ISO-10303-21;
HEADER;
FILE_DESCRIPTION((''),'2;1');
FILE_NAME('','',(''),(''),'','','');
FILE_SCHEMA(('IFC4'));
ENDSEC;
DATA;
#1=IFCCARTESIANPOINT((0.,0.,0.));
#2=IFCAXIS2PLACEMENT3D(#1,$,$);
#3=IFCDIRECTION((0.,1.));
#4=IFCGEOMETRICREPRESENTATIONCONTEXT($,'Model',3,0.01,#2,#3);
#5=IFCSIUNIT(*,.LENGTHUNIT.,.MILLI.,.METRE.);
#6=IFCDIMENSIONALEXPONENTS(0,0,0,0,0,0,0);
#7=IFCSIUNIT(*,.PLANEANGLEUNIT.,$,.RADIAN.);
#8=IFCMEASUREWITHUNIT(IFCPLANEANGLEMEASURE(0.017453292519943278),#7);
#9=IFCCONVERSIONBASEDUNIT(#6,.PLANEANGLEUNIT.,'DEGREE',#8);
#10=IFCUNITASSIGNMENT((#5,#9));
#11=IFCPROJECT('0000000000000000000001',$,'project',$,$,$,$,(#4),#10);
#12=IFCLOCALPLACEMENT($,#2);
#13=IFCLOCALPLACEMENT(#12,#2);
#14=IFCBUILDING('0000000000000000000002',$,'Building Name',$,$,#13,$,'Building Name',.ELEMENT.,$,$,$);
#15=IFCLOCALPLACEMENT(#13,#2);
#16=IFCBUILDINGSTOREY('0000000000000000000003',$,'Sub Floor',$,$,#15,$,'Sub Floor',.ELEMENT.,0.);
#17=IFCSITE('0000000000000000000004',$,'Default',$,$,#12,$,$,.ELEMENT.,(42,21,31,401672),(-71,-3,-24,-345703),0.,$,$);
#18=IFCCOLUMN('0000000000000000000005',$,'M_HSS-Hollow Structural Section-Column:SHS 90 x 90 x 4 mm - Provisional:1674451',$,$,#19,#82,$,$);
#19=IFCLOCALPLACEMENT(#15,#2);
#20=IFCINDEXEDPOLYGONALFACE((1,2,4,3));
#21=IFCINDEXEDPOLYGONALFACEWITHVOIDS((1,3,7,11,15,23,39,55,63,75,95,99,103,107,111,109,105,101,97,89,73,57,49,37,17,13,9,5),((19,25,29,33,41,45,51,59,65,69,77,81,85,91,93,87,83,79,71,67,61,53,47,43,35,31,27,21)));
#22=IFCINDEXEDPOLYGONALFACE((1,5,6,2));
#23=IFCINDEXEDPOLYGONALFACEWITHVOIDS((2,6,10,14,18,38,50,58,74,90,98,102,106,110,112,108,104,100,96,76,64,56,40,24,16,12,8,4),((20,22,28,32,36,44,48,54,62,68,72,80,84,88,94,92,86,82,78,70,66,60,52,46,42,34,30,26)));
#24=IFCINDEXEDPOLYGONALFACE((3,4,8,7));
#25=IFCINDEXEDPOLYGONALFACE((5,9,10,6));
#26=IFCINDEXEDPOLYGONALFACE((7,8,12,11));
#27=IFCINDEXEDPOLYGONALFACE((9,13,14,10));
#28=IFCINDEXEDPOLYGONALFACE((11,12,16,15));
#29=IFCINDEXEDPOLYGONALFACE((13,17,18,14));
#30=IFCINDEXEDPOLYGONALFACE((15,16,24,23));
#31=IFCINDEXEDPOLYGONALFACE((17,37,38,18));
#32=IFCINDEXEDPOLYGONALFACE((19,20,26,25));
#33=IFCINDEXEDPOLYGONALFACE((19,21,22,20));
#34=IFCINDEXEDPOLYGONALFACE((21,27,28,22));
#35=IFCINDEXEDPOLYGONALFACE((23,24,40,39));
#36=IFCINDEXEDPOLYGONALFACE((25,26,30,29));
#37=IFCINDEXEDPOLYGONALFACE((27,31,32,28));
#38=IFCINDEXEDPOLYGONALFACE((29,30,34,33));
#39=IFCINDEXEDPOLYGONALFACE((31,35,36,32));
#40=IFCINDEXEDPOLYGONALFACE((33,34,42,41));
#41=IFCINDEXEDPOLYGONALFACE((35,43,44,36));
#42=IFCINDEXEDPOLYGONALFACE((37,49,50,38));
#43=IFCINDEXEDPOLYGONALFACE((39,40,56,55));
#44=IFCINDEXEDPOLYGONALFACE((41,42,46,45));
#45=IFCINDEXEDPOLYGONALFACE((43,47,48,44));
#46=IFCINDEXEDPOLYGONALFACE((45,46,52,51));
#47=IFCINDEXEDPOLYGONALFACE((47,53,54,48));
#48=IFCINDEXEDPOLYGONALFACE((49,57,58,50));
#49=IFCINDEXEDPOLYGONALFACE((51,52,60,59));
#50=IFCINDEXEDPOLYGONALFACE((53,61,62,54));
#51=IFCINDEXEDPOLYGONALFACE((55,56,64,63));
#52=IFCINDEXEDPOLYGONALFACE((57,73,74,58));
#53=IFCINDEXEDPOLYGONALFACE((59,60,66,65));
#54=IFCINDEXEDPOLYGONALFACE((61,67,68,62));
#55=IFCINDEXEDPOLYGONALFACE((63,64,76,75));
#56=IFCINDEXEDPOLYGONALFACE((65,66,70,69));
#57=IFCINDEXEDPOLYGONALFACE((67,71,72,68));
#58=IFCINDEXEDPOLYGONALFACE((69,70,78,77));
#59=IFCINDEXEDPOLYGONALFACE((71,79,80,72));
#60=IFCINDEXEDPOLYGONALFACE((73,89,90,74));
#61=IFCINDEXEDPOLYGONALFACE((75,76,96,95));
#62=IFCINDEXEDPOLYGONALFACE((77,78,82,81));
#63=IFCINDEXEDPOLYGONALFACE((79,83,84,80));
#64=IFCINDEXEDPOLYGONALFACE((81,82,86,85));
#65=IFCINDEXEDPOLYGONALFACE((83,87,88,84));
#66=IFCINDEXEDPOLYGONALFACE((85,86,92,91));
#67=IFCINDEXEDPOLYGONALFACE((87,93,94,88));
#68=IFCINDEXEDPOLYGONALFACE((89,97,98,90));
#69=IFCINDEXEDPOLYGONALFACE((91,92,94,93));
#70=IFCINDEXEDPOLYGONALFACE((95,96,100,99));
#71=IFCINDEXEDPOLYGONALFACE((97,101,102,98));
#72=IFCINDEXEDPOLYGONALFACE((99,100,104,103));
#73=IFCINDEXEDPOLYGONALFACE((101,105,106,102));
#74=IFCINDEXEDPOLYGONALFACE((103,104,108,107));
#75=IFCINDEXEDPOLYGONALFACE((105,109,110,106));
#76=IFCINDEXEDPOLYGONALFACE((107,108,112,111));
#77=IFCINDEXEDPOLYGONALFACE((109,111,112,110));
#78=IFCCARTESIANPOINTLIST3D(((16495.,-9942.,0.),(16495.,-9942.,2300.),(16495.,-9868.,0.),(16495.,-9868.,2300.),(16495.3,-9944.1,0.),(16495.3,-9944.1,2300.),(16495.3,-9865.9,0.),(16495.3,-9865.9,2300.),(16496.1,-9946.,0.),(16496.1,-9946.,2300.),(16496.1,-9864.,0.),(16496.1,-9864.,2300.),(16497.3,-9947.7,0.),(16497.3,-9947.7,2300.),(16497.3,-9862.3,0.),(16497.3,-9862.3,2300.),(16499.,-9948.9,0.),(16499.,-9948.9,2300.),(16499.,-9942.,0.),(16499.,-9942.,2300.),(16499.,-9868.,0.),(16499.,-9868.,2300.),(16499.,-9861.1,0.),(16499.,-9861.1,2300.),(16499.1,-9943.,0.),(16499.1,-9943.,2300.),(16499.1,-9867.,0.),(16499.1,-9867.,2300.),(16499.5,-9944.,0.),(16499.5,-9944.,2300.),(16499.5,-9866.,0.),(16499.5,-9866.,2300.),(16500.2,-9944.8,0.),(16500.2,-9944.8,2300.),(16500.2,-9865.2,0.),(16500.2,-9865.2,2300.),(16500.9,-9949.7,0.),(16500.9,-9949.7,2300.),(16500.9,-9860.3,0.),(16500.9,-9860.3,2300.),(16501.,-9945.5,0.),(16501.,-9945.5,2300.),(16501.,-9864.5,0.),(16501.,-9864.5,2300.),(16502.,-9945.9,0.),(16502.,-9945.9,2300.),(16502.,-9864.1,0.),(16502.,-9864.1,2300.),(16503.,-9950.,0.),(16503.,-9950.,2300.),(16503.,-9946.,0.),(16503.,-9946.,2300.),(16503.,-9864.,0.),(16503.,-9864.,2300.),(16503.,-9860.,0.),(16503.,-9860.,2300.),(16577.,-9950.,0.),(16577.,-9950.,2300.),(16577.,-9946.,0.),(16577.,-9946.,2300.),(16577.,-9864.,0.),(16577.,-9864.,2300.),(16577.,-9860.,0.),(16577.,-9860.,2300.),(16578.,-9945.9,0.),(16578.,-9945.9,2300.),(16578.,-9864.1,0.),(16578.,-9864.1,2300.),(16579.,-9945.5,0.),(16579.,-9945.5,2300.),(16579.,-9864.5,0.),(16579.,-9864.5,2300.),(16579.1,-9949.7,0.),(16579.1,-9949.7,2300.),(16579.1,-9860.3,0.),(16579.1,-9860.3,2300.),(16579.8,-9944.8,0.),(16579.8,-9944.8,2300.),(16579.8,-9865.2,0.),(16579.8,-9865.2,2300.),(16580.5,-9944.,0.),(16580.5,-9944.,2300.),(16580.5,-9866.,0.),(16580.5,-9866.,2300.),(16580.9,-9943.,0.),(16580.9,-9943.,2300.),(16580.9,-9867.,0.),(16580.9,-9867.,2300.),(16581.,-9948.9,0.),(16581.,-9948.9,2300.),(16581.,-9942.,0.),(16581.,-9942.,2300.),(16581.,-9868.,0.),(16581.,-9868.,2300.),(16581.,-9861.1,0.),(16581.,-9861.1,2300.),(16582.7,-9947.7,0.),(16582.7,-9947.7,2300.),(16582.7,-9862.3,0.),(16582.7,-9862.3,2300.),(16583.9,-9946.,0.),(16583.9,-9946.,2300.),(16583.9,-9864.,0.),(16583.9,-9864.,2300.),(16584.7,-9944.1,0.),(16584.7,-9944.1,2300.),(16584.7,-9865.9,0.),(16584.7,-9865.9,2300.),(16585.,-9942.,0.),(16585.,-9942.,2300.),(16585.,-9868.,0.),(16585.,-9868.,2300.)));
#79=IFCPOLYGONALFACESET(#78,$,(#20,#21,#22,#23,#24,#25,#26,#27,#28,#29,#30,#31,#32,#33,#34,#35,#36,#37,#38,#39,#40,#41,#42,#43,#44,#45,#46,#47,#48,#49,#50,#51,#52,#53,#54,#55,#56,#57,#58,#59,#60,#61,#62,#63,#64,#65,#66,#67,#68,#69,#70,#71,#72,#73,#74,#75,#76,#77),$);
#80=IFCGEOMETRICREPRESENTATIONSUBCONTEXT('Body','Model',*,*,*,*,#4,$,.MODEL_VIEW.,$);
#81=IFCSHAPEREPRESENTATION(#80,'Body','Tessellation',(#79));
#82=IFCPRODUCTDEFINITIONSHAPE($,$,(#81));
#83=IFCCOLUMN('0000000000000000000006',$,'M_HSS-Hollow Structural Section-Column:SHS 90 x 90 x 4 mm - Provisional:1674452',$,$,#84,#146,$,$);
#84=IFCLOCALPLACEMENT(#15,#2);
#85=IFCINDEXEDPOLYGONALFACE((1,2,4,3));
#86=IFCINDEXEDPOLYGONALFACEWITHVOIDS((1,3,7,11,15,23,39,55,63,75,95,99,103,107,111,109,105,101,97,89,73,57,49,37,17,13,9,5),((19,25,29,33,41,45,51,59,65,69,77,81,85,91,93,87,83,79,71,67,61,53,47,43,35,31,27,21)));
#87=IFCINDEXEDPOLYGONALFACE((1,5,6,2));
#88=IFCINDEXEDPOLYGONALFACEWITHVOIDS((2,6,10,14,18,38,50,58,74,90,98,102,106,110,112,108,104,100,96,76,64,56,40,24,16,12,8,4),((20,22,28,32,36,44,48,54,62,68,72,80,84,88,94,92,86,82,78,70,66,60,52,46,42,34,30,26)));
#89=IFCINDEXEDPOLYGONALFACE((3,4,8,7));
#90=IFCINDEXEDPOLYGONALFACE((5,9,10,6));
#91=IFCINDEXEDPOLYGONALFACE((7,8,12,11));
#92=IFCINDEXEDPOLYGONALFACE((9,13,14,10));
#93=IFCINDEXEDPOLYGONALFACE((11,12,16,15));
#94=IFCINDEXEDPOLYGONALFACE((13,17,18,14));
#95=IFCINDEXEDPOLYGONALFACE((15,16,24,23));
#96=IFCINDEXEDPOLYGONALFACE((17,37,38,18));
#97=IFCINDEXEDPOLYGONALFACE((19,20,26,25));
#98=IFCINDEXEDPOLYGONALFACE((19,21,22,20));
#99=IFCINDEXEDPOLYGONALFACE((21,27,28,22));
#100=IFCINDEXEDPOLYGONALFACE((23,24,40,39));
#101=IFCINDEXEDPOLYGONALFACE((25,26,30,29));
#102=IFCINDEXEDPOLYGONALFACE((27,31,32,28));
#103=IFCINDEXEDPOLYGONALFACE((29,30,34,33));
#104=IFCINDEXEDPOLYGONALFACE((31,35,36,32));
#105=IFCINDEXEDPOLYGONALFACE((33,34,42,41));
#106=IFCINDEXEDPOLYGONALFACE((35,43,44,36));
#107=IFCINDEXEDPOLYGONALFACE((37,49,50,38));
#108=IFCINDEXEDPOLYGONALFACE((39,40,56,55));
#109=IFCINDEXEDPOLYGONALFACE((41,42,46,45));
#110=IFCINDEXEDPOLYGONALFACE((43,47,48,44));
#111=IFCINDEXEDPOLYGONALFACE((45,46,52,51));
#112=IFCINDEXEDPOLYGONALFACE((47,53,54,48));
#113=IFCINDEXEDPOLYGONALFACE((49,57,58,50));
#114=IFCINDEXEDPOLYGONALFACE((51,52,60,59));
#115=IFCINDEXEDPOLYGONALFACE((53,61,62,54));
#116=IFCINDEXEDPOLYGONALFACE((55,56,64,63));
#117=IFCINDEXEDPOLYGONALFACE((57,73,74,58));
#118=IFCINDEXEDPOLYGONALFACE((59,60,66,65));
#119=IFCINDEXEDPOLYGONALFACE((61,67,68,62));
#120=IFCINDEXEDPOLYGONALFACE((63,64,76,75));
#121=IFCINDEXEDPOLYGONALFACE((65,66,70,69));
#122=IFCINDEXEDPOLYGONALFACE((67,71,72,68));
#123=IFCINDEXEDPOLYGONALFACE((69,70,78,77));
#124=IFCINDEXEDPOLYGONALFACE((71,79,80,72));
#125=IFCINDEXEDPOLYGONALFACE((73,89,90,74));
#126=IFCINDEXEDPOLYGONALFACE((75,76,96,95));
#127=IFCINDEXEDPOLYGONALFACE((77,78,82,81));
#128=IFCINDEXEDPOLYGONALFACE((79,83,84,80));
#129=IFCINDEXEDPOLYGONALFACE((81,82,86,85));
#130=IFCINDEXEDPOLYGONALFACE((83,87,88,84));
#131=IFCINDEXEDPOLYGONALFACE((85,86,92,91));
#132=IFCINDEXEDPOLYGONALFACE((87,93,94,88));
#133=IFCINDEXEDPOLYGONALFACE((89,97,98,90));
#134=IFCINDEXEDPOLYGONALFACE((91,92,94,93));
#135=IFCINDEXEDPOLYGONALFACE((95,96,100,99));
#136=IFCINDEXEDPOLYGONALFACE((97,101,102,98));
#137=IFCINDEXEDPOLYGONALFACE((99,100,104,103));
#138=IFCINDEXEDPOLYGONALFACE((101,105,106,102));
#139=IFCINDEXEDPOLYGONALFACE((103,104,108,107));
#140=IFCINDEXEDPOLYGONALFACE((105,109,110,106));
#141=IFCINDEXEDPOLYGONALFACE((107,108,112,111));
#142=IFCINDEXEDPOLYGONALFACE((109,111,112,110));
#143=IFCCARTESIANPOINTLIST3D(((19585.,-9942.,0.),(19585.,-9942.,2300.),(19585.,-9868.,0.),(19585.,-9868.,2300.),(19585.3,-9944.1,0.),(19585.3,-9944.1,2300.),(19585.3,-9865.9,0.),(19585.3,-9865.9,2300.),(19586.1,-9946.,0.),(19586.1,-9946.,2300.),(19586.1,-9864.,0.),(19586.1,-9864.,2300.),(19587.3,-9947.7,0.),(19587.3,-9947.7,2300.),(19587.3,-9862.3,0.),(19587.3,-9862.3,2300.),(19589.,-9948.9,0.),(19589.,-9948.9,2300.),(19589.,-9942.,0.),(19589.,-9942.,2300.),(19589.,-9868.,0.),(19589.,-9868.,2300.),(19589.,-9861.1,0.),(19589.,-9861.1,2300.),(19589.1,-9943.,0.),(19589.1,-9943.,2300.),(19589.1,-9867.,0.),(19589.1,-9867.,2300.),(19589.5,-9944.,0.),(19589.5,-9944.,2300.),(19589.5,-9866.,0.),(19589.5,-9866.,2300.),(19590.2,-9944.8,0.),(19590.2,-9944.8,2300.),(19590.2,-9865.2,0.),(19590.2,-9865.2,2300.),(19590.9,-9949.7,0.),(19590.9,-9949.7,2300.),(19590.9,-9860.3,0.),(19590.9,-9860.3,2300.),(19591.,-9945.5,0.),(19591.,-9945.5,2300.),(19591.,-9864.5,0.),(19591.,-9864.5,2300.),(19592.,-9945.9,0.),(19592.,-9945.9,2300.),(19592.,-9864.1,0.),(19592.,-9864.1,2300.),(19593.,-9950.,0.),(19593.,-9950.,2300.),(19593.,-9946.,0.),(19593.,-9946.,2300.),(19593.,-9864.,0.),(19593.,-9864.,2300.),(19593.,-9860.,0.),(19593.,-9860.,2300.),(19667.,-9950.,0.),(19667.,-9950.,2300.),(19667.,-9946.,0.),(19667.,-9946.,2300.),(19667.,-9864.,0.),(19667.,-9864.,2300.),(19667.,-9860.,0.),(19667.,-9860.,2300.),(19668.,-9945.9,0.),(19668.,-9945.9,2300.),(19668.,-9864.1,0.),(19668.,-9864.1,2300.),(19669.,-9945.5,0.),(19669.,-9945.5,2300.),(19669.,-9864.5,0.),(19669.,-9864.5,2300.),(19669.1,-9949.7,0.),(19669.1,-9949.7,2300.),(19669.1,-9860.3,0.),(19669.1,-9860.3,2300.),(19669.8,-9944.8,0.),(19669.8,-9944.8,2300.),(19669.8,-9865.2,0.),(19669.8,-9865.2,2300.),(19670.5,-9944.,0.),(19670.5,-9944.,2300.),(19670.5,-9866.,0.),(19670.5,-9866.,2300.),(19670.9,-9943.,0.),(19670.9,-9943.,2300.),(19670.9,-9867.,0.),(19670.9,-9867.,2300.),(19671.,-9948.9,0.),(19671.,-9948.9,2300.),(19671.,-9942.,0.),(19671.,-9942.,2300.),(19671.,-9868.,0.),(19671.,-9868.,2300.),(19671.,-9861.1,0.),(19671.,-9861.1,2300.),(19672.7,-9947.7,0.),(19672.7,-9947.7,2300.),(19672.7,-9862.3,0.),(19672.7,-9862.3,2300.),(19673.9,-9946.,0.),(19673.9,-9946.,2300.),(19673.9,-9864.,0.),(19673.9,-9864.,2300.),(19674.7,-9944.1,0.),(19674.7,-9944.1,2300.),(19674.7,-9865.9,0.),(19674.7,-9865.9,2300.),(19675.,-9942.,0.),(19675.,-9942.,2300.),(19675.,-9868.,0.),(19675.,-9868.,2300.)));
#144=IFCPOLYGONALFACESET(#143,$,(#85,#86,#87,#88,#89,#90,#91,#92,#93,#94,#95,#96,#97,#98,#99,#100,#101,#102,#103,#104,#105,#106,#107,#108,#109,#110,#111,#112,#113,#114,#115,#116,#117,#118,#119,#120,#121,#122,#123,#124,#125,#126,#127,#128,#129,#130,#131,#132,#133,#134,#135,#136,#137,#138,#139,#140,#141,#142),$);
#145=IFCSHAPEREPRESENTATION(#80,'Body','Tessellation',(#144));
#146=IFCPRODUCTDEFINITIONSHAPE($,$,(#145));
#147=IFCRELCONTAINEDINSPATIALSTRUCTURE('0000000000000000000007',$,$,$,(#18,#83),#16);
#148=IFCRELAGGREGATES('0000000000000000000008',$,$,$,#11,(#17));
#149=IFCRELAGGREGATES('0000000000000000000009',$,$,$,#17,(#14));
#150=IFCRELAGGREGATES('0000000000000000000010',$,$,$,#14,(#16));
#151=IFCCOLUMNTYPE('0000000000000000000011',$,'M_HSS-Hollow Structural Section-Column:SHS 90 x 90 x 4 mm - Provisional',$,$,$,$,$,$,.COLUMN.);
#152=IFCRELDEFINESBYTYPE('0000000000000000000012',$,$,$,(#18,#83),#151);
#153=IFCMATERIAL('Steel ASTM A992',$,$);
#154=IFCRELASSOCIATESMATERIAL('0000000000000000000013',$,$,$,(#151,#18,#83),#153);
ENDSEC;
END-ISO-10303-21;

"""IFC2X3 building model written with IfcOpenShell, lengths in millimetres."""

from ifc_helpers import new_model, entity, si_unit, converted_unit, direction, frame, frame_2d, origin, place, context, subcontext, project, spatial, polyline, circle_curve, parameter, trimmed, segment, composite_curve, outline, extrude, source, transform, mapped, material, type_object, type_shapes, element, save


model = new_model("IFC2X3")

# Units and contexts
model_context = context("Model", 3, precision=0.01, world=origin(), true_north=direction((0.0, 1.0)))
body_context = subcontext(model_context, "Body", "Model", "MODEL_VIEW")
ifc_project = project(units=[si_unit("LENGTHUNIT", "METRE", prefix="MILLI"), converted_unit("PLANEANGLEUNIT", "DEGREE", entity("IfcPlaneAngleMeasure", 0.017453292519943278), si_unit("PLANEANGLEUNIT", "RADIAN"), dimensions=[0, 0, 0, 0, 0, 0, 0])], contexts=[model_context])

# Site, building, storey
site_placement = place(None, origin())
site = spatial("IfcSite", under=ifc_project, at=site_placement, Name="Default", CompositionType="ELEMENT", RefLatitude=(42, 21, 31, 401672), RefLongitude=(-71, -3, -24, -345703), RefElevation=0.0)
building_placement = place(site_placement, origin())
building = spatial("IfcBuilding", under=site, at=building_placement, Name="Building Name", LongName="Building Name", CompositionType="ELEMENT")
storey_placement = place(building_placement, origin())
storey = spatial("IfcBuildingStorey", under=building, at=storey_placement, Name="Sub Floor", LongName="Sub Floor", CompositionType="ELEMENT", Elevation=0.0)

# Columns
ifc_material_1 = material(Name="Steel ASTM A992")
column_type = type_object("IfcColumnType", Name="M_HSS-Hollow Structural Section-Column:SHS 90 x 90 x 4 mm - Provisional", PredefinedType="COLUMN", material=ifc_material_1)
shared_shape_1 = source(origin(), body_context, "Body", "SweptSolid", [
    extrude(outline(composite_curve([segment(polyline([(-37.0, -45.0), (37.0, -45.0)]), True, "CONTINUOUS"), segment(trimmed(circle_curve(frame_2d((37.0, -37.0), x_axis=(-1.0, 0.0)), 8.0), [parameter(90.0)], [parameter(180.0)], True, "PARAMETER"), True, "CONTINUOUS"), segment(polyline([(45.0, -37.0), (45.0, 37.0)]), True, "CONTINUOUS"), segment(trimmed(circle_curve(frame_2d((37.0, 37.0), x_axis=(-1.0, 0.0)), 8.0), [parameter(180.0)], [parameter(270.0)], True, "PARAMETER"), True, "CONTINUOUS"), segment(polyline([(37.0, 45.0), (-37.0, 45.0)]), True, "CONTINUOUS"), segment(trimmed(circle_curve(frame_2d((-37.0, 37.0), x_axis=(-1.0, 0.0)), 8.0), [parameter(270.0)], [parameter(360.0)], True, "PARAMETER"), True, "CONTINUOUS"), segment(polyline([(-45.0, 37.0), (-45.0, -37.0)]), True, "CONTINUOUS"), segment(trimmed(circle_curve(frame_2d((-37.0, -37.0), x_axis=(-1.0, 0.0)), 8.0), [parameter(360.0)], [parameter(90.0)], True, "PARAMETER"), True, "CONTINUOUS")], self_intersect=False), holes=[composite_curve([segment(trimmed(circle_curve(frame_2d((-37.0, -37.0), x_axis=(-1.0, 0.0)), 4.0), [parameter(0.0)], [parameter(90.0)], True, "PARAMETER"), False, "CONTINUOUS"), segment(polyline([(-41.0, -37.0), (-41.0, 37.0)]), True, "CONTINUOUS"), segment(trimmed(circle_curve(frame_2d((-37.0, 37.0), x_axis=(-1.0, 0.0)), 4.0), [parameter(270.0)], [parameter(0.0)], True, "PARAMETER"), False, "CONTINUOUS"), segment(polyline([(-37.0, 41.0), (37.0, 41.0)]), True, "CONTINUOUS"), segment(trimmed(circle_curve(frame_2d((37.0, 37.0), x_axis=(-1.0, 0.0)), 4.0), [parameter(180.0)], [parameter(270.0)], True, "PARAMETER"), False, "CONTINUOUS"), segment(polyline([(41.0, 37.0), (41.0, -37.0)]), True, "CONTINUOUS"), segment(trimmed(circle_curve(frame_2d((37.0, -37.0), x_axis=(-1.0, 0.0)), 4.0), [parameter(90.0)], [parameter(180.0)], True, "PARAMETER"), False, "CONTINUOUS"), segment(polyline([(37.0, -41.0), (-37.0, -41.0)]), True, "CONTINUOUS")], self_intersect=False)]), frame((0.0, 0.0, 0.0), z_axis=(0.0, 0.0, 1.0), x_axis=(-1.0, 0.0, 0.0)), (0.0, 0.0, 1.0), 2300.0),
])
type_shapes(column_type, [shared_shape_1])
for number, where, name in (
    (1, (16540.0, -9905.0, 0.0), "M_HSS-Hollow Structural Section-Column:SHS 90 x 90 x 4 mm - Provisional:1674451"),
    (2, (19630.0, -9905.0, 0.0), "M_HSS-Hollow Structural Section-Column:SHS 90 x 90 x 4 mm - Provisional:1674452"),
):
    element("IfcColumn", number, at=place(storey_placement, frame(where)), inside=storey, type_object=column_type, material=ifc_material_1, Name=name, context=body_context, shape_type="MappedRepresentation", body=[
        mapped(shared_shape_1, transform((0.0, 0.0, 0.0), scale=1.0)),
    ])

save(model, "model.ifc")
